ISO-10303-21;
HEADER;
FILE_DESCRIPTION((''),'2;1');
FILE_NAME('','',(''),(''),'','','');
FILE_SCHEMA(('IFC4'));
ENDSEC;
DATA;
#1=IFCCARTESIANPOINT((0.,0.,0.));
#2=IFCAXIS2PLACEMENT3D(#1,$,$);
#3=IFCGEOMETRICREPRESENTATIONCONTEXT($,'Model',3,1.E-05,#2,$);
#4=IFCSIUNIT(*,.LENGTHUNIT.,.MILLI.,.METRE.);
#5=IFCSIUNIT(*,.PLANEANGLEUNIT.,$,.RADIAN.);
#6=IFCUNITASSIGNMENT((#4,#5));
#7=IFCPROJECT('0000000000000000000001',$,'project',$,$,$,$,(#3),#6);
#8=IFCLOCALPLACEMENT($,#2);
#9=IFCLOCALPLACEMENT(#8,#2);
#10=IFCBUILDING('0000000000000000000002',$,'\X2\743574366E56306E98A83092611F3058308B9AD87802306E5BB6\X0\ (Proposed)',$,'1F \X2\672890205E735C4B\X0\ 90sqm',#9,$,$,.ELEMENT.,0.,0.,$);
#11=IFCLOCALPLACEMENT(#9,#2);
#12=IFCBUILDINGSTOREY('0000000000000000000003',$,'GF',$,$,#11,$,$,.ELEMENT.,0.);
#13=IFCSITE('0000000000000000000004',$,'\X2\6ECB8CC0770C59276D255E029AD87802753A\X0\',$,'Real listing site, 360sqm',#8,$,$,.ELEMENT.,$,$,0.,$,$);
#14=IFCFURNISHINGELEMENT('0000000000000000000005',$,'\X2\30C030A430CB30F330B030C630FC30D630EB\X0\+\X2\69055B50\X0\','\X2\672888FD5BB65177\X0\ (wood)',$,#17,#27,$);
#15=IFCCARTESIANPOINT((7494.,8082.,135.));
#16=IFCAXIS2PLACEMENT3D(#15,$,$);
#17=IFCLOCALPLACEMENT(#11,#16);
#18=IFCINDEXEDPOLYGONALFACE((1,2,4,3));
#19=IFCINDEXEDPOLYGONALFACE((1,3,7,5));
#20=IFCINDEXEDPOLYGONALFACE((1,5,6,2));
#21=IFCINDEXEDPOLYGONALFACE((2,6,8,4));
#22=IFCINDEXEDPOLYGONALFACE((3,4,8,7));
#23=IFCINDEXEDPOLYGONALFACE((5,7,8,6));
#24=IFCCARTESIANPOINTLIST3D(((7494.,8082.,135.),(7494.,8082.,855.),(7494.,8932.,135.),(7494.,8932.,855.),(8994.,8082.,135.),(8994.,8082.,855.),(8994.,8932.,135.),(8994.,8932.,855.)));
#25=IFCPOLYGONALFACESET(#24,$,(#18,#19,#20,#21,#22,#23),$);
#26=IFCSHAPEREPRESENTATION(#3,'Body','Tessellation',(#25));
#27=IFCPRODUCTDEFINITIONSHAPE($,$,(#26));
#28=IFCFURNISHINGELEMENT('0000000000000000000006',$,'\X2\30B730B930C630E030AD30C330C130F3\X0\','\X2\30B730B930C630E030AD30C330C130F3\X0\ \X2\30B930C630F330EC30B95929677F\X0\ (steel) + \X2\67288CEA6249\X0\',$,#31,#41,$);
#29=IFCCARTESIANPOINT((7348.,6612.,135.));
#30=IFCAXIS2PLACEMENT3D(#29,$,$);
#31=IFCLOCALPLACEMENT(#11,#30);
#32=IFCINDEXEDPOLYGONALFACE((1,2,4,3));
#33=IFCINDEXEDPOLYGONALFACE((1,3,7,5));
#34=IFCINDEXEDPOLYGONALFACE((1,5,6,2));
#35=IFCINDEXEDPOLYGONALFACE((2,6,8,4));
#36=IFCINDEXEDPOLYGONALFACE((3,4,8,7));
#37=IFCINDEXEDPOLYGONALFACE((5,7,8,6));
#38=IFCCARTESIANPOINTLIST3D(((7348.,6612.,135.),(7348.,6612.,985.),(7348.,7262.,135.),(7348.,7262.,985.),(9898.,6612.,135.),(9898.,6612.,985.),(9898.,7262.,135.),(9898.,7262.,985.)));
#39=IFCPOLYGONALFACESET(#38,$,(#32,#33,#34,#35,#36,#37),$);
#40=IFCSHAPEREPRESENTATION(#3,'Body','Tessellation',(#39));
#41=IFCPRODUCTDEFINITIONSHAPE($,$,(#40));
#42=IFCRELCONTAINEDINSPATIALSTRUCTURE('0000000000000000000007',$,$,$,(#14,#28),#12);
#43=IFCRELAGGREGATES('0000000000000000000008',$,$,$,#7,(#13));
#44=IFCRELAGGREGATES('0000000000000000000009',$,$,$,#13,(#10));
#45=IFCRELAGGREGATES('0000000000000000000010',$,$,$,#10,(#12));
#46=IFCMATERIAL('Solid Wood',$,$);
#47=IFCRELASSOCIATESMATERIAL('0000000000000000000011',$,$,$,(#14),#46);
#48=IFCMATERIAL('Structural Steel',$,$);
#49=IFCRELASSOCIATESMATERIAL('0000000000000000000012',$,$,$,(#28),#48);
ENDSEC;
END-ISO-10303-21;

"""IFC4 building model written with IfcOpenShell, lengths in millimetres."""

from ifc_helpers import new_model, si_unit, frame, frame_2d, origin, place, context, project, spatial, rectangle, extrude, material, element, save


model = new_model("IFC4")

# Units and contexts
model_context = context("Model", 3, precision=1e-05, world=origin())
ifc_project = project(units=[si_unit("LENGTHUNIT", "METRE", prefix="MILLI"), si_unit("PLANEANGLEUNIT", "RADIAN")], contexts=[model_context])

# Site, building, storey
site_placement = place(None, origin())
site = spatial("IfcSite", under=ifc_project, at=site_placement, Name="滋賀県大津市高砂町", ObjectType="Real listing site, 360sqm", CompositionType="ELEMENT", RefElevation=0.0)
building_placement = place(site_placement, origin())
building = spatial("IfcBuilding", under=site, at=building_placement, Name="琵琶湖の風を感じる高砂の家 (Proposed)", ObjectType="1F 木造平屋 90sqm", CompositionType="ELEMENT", ElevationOfRefHeight=0.0, ElevationOfTerrain=0.0)
storey_placement = place(building_placement, origin())
storey = spatial("IfcBuildingStorey", under=building, at=storey_placement, Name="GF", CompositionType="ELEMENT", Elevation=0.0)

# Shared definitions
ifc_material_1 = material(Name="Solid Wood")

# Shared definitions
ifc_material_2 = material(Name="Structural Steel")

# Furnishing elements
furnishing_1_placement = place(storey_placement, frame((7494.0, 8082.0, 135.0)))
element("IfcFurnishingElement", 1, at=furnishing_1_placement, inside=storey, material=ifc_material_1, Name="ダイニングテーブル+椅子", Description="木製家具 (wood)", context=model_context, shape_type="SweptSolid", body=[
    extrude(rectangle(XDim=1500.0, YDim=850.0, at=frame_2d((750.0, 425.0))), frame((7494.0, 8082.0, 135.0)), (0.0, 0.0, 1.0), 720.0),
])
furnishing_2_placement = place(storey_placement, frame((7348.0, 6612.0, 135.0)))
element("IfcFurnishingElement", 2, at=furnishing_2_placement, inside=storey, material=ifc_material_2, Name="システムキッチン", Description="システムキッチン ステンレス天板 (steel) + 木質扉", context=model_context, shape_type="SweptSolid", body=[
    extrude(rectangle(XDim=2550.0, YDim=650.0, at=frame_2d((1275.0, 325.0))), frame((7348.0, 6612.0, 135.0)), (0.0, 0.0, 1.0), 850.0),
])

save(model, "model.ifc")
